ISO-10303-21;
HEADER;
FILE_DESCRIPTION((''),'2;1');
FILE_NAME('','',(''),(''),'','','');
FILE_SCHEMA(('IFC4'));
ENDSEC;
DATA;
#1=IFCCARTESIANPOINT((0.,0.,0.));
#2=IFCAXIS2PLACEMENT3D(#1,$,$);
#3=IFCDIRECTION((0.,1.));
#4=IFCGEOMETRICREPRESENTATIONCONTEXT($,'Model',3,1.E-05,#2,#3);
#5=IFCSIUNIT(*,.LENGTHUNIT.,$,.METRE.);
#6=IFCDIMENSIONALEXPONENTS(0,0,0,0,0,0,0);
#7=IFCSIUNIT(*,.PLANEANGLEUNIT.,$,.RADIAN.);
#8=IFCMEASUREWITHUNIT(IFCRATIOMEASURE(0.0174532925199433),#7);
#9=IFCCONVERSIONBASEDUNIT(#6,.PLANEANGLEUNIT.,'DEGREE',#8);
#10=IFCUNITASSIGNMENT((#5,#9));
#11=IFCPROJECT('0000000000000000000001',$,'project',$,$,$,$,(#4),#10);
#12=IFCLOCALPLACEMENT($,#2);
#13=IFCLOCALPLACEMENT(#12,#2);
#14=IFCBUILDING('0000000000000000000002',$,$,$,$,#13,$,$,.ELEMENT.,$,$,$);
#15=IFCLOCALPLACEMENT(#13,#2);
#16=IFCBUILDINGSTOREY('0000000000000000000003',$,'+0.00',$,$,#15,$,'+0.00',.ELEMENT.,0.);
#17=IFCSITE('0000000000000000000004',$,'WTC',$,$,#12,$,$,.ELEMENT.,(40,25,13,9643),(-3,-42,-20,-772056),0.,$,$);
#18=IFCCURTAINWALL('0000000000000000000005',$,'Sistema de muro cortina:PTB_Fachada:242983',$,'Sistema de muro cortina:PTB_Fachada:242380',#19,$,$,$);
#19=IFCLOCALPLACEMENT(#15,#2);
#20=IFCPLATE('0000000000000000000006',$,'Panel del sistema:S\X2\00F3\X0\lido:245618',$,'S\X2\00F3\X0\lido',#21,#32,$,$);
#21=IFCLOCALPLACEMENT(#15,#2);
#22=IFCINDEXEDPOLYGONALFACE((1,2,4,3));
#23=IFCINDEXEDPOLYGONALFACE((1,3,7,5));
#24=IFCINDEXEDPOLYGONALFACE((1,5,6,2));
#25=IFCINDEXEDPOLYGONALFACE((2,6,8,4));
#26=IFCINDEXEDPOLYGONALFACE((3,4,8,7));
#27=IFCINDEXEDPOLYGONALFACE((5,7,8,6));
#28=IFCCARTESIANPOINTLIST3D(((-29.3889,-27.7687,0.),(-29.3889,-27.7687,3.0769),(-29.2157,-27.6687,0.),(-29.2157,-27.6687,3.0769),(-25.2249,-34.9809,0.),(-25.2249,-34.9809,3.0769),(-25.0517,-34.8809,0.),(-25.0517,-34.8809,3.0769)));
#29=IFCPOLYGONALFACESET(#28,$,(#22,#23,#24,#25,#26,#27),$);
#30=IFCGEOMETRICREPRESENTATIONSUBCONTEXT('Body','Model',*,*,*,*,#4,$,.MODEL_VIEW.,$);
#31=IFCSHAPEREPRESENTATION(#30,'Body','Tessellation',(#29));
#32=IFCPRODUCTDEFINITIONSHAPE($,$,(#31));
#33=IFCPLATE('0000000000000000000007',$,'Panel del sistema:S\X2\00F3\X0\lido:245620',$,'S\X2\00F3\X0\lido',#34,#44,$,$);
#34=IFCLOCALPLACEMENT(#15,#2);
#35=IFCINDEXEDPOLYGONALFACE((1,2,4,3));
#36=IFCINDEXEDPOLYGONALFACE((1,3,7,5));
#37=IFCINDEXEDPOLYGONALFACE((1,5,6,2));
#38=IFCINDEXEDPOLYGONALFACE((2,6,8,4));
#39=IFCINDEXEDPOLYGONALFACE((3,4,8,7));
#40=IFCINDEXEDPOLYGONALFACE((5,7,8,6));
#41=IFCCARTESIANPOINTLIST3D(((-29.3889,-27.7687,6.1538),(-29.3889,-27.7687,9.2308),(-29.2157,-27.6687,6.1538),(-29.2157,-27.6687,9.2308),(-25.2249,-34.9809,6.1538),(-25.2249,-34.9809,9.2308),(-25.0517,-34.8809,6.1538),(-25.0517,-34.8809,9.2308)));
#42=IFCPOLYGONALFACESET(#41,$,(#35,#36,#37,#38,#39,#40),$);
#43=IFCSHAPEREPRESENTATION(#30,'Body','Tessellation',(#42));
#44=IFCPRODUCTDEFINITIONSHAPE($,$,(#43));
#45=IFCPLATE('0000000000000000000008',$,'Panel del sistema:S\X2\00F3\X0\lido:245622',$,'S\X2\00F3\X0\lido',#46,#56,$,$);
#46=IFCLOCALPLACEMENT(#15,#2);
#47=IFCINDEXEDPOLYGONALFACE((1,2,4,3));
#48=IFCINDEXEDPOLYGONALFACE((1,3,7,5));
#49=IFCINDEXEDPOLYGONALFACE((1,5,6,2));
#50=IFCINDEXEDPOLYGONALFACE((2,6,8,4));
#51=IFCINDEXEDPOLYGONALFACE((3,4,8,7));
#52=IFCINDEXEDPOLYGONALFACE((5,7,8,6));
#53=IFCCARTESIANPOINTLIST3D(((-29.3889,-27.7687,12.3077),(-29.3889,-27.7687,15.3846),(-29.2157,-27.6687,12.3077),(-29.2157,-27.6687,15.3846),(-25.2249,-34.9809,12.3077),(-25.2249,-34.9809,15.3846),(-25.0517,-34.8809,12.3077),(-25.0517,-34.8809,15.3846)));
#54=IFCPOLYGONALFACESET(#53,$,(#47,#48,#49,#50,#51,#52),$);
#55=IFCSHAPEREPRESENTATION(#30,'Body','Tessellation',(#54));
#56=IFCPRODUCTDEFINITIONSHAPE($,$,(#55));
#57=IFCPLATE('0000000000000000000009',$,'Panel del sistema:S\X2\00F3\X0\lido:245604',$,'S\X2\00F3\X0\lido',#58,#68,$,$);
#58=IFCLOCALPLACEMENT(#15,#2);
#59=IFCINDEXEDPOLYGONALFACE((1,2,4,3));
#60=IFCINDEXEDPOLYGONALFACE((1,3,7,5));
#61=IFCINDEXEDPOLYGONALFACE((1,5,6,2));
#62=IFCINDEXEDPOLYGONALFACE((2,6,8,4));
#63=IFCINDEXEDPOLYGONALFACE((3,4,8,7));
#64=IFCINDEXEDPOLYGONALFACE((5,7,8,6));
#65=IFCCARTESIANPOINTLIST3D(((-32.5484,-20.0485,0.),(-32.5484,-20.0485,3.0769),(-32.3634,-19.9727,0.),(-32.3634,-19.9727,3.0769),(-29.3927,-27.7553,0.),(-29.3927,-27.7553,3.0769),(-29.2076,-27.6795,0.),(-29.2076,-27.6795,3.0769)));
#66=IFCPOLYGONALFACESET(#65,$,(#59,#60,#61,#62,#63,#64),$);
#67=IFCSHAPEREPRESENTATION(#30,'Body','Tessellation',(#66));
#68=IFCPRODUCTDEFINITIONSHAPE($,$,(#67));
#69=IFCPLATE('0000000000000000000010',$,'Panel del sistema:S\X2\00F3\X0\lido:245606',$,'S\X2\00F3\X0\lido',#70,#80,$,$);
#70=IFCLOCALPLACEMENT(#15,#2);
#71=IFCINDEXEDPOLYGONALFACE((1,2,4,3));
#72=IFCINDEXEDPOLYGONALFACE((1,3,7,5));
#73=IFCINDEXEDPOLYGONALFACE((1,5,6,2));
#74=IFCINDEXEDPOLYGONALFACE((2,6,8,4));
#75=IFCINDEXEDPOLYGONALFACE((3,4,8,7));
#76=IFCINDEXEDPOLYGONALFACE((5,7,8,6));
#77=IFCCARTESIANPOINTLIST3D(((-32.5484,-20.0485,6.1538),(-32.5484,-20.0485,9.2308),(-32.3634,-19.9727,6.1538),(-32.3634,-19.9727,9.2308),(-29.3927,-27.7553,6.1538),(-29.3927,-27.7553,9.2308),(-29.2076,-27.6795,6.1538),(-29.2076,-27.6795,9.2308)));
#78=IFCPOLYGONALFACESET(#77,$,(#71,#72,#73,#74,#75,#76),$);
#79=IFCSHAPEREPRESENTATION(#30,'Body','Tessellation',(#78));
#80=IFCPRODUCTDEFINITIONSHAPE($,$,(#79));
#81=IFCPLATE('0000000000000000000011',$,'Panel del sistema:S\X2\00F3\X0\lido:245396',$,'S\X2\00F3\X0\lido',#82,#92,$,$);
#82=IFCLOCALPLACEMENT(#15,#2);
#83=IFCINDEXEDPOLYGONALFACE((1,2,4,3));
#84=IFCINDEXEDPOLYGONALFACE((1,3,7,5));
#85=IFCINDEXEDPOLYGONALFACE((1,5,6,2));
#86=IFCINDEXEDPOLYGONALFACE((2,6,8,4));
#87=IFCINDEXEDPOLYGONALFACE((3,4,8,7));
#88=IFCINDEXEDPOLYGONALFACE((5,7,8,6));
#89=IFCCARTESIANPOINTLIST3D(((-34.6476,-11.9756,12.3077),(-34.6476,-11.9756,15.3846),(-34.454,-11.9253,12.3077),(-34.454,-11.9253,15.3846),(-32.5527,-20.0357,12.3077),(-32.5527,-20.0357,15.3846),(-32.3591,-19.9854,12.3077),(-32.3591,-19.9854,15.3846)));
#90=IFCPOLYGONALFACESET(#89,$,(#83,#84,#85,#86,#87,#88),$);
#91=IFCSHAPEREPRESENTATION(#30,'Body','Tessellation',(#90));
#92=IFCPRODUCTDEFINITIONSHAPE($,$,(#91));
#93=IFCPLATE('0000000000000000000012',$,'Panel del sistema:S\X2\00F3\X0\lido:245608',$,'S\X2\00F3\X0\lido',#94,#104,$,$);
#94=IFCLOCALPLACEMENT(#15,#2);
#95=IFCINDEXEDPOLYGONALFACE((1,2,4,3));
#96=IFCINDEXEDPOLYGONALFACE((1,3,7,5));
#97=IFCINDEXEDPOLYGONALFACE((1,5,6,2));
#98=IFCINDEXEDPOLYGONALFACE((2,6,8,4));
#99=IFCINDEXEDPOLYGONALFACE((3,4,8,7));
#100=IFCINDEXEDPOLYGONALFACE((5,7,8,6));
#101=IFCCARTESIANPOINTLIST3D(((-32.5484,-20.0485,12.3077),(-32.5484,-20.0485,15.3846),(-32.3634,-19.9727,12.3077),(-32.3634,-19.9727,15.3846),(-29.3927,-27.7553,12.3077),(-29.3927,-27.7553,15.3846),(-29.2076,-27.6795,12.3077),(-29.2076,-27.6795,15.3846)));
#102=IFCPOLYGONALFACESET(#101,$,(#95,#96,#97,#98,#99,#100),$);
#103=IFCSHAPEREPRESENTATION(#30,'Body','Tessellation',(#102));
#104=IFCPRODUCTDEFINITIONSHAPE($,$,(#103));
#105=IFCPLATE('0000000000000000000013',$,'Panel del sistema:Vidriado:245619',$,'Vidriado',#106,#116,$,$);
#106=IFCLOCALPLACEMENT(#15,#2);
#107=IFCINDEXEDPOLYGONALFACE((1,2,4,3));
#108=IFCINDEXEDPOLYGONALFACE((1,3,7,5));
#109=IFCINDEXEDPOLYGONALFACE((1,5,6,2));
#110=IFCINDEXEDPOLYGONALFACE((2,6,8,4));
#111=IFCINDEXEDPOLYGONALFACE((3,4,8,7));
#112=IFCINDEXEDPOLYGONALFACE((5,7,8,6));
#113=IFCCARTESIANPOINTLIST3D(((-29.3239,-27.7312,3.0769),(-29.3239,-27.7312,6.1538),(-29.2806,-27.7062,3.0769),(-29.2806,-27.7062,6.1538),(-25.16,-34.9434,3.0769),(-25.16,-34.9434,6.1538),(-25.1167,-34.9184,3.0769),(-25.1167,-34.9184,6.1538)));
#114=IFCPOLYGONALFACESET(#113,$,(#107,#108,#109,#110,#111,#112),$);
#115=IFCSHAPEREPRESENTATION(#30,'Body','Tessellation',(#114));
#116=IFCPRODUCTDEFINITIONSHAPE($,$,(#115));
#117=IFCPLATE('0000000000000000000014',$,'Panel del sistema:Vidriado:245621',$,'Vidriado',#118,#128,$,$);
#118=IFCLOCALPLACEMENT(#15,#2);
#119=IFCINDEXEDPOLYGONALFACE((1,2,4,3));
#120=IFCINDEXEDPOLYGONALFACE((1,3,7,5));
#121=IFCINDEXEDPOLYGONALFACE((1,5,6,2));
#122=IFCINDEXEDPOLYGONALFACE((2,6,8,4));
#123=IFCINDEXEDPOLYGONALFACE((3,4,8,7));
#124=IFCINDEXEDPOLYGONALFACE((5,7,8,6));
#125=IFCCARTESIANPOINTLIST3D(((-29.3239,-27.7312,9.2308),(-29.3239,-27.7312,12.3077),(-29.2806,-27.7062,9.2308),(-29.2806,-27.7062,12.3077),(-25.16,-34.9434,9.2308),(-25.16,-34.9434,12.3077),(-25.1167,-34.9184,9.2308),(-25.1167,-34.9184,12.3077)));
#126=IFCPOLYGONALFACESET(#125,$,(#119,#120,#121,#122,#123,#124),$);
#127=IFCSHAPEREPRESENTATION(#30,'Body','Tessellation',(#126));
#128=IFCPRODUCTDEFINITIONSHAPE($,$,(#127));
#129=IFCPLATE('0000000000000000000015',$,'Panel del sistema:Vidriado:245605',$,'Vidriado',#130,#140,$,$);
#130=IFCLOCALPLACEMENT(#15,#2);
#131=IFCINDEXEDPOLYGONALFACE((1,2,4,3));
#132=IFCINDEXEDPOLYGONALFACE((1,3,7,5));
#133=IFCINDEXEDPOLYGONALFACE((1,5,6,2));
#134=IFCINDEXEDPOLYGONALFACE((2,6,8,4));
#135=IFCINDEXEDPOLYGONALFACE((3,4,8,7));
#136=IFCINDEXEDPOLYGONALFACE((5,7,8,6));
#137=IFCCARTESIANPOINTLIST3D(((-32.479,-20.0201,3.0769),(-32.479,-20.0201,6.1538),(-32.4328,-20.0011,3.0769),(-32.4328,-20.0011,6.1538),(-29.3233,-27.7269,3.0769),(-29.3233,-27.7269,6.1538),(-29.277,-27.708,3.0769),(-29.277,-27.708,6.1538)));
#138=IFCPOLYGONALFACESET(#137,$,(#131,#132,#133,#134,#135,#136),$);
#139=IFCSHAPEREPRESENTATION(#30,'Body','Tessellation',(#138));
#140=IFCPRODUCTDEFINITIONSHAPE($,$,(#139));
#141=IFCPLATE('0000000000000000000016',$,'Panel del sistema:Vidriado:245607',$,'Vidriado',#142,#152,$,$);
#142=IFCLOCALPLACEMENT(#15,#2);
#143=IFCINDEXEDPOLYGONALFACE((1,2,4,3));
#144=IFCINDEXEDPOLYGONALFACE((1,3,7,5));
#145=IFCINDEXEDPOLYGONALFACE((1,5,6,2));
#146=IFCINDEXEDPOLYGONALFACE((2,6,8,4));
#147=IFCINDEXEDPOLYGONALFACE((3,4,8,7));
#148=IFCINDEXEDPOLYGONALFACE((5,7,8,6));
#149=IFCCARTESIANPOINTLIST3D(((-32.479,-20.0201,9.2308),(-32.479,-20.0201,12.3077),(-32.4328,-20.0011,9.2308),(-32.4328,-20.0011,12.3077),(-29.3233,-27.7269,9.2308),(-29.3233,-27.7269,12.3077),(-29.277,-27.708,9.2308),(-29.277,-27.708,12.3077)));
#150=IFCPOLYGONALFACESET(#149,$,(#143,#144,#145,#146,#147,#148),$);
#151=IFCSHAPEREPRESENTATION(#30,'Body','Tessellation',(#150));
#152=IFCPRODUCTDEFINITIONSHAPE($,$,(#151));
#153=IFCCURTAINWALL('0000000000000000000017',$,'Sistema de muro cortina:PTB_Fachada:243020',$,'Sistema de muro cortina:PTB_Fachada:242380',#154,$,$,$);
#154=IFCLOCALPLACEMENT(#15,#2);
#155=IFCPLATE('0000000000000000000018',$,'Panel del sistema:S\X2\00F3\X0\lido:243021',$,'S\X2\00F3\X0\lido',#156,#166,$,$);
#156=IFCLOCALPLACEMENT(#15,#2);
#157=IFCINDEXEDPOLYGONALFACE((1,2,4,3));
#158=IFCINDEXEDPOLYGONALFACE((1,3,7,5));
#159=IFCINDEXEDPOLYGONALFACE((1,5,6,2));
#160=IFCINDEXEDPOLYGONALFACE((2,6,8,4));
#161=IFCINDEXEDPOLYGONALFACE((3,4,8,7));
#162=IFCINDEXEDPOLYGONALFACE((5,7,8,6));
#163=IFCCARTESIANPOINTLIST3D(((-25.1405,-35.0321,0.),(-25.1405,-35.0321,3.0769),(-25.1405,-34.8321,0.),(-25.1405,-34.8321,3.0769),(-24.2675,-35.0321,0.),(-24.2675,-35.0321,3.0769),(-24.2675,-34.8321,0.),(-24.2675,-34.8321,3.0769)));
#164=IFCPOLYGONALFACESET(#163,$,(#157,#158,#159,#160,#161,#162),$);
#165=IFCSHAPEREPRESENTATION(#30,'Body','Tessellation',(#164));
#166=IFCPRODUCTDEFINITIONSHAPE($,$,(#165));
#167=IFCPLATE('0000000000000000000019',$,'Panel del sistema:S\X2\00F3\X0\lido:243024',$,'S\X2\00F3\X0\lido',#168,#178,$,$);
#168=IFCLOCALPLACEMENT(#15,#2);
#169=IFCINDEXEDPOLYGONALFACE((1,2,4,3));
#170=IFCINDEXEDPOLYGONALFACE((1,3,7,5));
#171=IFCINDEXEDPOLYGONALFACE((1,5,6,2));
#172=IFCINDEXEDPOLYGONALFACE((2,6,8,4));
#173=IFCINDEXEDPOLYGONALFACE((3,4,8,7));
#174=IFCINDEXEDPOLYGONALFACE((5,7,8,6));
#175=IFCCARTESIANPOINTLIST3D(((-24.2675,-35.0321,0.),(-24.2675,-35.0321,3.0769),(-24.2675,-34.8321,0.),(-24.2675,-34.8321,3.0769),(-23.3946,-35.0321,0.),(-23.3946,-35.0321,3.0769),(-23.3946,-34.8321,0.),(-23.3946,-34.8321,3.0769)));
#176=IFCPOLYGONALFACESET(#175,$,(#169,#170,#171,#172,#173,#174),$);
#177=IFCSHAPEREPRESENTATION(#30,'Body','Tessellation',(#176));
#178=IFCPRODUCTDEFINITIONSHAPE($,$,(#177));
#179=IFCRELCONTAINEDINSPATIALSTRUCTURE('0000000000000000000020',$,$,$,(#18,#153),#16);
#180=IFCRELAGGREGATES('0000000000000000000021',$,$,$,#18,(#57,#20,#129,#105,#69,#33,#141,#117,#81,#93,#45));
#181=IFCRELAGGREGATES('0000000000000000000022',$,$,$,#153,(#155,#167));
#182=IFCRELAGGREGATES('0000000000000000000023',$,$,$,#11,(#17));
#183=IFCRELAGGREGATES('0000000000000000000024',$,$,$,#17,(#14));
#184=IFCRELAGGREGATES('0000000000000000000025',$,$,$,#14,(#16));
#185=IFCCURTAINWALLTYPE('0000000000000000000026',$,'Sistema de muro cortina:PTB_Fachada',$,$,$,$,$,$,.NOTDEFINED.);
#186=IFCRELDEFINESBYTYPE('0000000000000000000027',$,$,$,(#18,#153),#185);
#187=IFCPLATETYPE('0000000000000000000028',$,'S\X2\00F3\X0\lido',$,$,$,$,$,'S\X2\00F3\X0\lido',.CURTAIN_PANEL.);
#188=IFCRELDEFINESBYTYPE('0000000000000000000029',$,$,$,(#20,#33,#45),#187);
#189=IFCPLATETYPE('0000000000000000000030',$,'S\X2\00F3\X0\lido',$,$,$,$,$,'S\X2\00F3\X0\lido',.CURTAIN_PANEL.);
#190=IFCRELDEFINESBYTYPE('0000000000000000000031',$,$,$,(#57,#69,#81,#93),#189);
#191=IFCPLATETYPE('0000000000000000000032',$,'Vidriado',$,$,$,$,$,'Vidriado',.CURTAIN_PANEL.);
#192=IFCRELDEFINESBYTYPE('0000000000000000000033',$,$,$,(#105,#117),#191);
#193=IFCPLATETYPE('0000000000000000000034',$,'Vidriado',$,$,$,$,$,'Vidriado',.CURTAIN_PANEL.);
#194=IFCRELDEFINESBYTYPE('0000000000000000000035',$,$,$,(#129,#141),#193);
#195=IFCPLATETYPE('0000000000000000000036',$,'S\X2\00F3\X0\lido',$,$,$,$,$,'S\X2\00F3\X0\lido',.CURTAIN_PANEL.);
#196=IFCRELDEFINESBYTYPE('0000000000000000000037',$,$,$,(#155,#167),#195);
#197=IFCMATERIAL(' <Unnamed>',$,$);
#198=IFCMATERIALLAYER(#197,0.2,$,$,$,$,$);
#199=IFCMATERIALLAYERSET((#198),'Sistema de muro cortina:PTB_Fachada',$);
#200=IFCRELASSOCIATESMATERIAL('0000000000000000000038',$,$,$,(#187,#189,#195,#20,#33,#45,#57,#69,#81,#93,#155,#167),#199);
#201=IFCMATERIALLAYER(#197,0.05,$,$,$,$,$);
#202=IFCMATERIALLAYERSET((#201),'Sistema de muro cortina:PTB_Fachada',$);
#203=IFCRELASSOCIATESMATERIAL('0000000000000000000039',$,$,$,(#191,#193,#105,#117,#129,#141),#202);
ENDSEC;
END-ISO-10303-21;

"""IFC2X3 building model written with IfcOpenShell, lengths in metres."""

from ifc_helpers import new_model, entity, si_unit, converted_unit, direction, frame, frame_2d, origin, origin_2d_with_axis, place, context, subcontext, project, spatial, rectangle, extrude, source, transform, mapped, material, layer, layer_set, layer_usage, type_object, type_shapes, element, aggregate, save


model = new_model("IFC2X3")

# Units and contexts
model_context = context("Model", 3, precision=1e-05, world=origin(), true_north=direction((0.0, 1.0)))
body_context = subcontext(model_context, "Body", "Model", "MODEL_VIEW")
ifc_project = project(units=[si_unit("LENGTHUNIT", "METRE"), converted_unit("PLANEANGLEUNIT", "DEGREE", entity("IfcRatioMeasure", 0.0174532925199433), si_unit("PLANEANGLEUNIT", "RADIAN"), dimensions=[0, 0, 0, 0, 0, 0, 0])], contexts=[model_context])

# Site, building, storey
site_placement = place(None, origin())
site = spatial("IfcSite", under=ifc_project, at=site_placement, Name="WTC", CompositionType="ELEMENT", RefLatitude=(40, 25, 13, 9643), RefLongitude=(-3, -42, -20, -772056), RefElevation=0.0)
building_placement = place(site_placement, origin())
building = spatial("IfcBuilding", under=site, at=building_placement, CompositionType="ELEMENT")
storey_placement = place(building_placement, origin())
storey = spatial("IfcBuildingStorey", under=building, at=storey_placement, Name="+0.00", LongName="+0.00", CompositionType="ELEMENT", Elevation=0.0)

# Curtain walls, plates
curtain_wall_type = type_object("IfcCurtainWallType", Name="Sistema de muro cortina:PTB_Fachada", PredefinedType="NOTDEFINED")
curtain_wall_1_placement = place(storey_placement, origin())
curtain_wall_1 = element("IfcCurtainWall", 1, at=curtain_wall_1_placement, inside=storey, type_object=curtain_wall_type, Name="Sistema de muro cortina:PTB_Fachada:242983", ObjectType="Sistema de muro cortina:PTB_Fachada:242380")
ifc_material_1 = material(Name=" <Unnamed>")
ifc_layer_1 = layer(ifc_material_1, 0.2)
ifc_layer_set_1 = layer_set([ifc_layer_1], Name="Sistema de muro cortina:PTB_Fachada")
ifc_layer_usage_1 = layer_usage(ifc_layer_set_1, "AXIS3", "POSITIVE", 0.0)
plate_type_1 = type_object("IfcPlateType", Name="Sólido", ElementType="Sólido", PredefinedType="CURTAIN_PANEL", material=ifc_layer_set_1)
shared_shape_1 = source(origin(), body_context, "Body", "SweptSolid", [
    extrude(rectangle(XDim=0.2, YDim=8.3279, at=origin_2d_with_axis()), frame((0.0, 0.0, 0.0), z_axis=(0.0, 0.0, 1.0), x_axis=(0.0, 1.0, 0.0)), (0.0, 0.0, 1.0), 3.0769),
])
type_shapes(plate_type_1, [shared_shape_1])
plate_1_placement = place(curtain_wall_1_placement, frame((-27.2203, -31.3248, 3.0769), z_axis=(0.0, 0.0, -1.0), x_axis=(0.5, -0.866025, 0.0)))
plate_1 = element("IfcPlate", 2, at=plate_1_placement, type_object=plate_type_1, material=ifc_layer_usage_1, Name="Panel del sistema:Sólido:245618", ObjectType="Sólido", context=body_context, shape_type="MappedRepresentation", body=[
    mapped(shared_shape_1, transform((0.0, 0.0, 0.0), scale=1.0)),
])
ifc_layer_usage_2 = layer_usage(ifc_layer_set_1, "AXIS3", "POSITIVE", 0.0)
plate_2_placement = place(curtain_wall_1_placement, frame((-27.2203, -31.3248, 9.2308), z_axis=(0.0, 0.0, -1.0), x_axis=(0.5, -0.866025, 0.0)))
plate_2 = element("IfcPlate", 3, at=plate_2_placement, type_object=plate_type_1, material=ifc_layer_usage_2, Name="Panel del sistema:Sólido:245620", ObjectType="Sólido", context=body_context, shape_type="MappedRepresentation", body=[
    mapped(shared_shape_1, transform((0.0, 0.0, 0.0), scale=1.0)),
])
ifc_layer_usage_3 = layer_usage(ifc_layer_set_1, "AXIS3", "POSITIVE", 0.0)
plate_3_placement = place(curtain_wall_1_placement, frame((-27.2203, -31.3248, 15.3846), z_axis=(0.0, 0.0, -1.0), x_axis=(0.5, -0.866025, 0.0)))
plate_3 = element("IfcPlate", 4, at=plate_3_placement, type_object=plate_type_1, material=ifc_layer_usage_3, Name="Panel del sistema:Sólido:245622", ObjectType="Sólido", context=body_context, shape_type="MappedRepresentation", body=[
    mapped(shared_shape_1, transform((0.0, 0.0, 0.0), scale=1.0)),
])
ifc_layer_usage_4 = layer_usage(ifc_layer_set_1, "AXIS3", "POSITIVE", 0.0)
plate_type_2 = type_object("IfcPlateType", Name="Sólido", ElementType="Sólido", PredefinedType="CURTAIN_PANEL", material=ifc_layer_set_1)
shared_shape_2 = source(origin(), body_context, "Body", "SweptSolid", [
    extrude(rectangle(XDim=0.2, YDim=8.3279, at=origin_2d_with_axis()), frame((0.0, 0.0, 0.0), z_axis=(0.0, 0.0, 1.0), x_axis=(0.0, 1.0, 0.0)), (0.0, 0.0, 1.0), 3.0769),
])
type_shapes(plate_type_2, [shared_shape_2])
plate_4_placement = place(curtain_wall_1_placement, frame((-30.878, -23.864, 3.0769), z_axis=(0.0, 0.0, -1.0), x_axis=(0.378935, -0.925423, 0.0)))
plate_4 = element("IfcPlate", 5, at=plate_4_placement, type_object=plate_type_2, material=ifc_layer_usage_4, Name="Panel del sistema:Sólido:245604", ObjectType="Sólido", context=body_context, shape_type="MappedRepresentation", body=[
    mapped(shared_shape_2, transform((0.0, 0.0, 0.0), scale=1.0)),
])
ifc_layer_usage_5 = layer_usage(ifc_layer_set_1, "AXIS3", "POSITIVE", 0.0)
plate_5_placement = place(curtain_wall_1_placement, frame((-30.878, -23.864, 9.2308), z_axis=(0.0, 0.0, -1.0), x_axis=(0.378935, -0.925423, 0.0)))
plate_5 = element("IfcPlate", 6, at=plate_5_placement, type_object=plate_type_2, material=ifc_layer_usage_5, Name="Panel del sistema:Sólido:245606", ObjectType="Sólido", context=body_context, shape_type="MappedRepresentation", body=[
    mapped(shared_shape_2, transform((0.0, 0.0, 0.0), scale=1.0)),
])
ifc_layer_usage_6 = layer_usage(ifc_layer_set_1, "AXIS3", "POSITIVE", 0.0)
plate_6_placement = place(curtain_wall_1_placement, frame((-33.5034, -15.9805, 15.3846), z_axis=(0.0, 0.0, -1.0), x_axis=(0.251552, -0.967844, 0.0)))
plate_6 = element("IfcPlate", 7, at=plate_6_placement, type_object=plate_type_2, material=ifc_layer_usage_6, Name="Panel del sistema:Sólido:245396", ObjectType="Sólido", context=body_context, shape_type="MappedRepresentation", body=[
    mapped(shared_shape_2, transform((0.0, 0.0, 0.0), scale=1.0)),
])
ifc_layer_usage_7 = layer_usage(ifc_layer_set_1, "AXIS3", "POSITIVE", 0.0)
plate_7_placement = place(curtain_wall_1_placement, frame((-30.878, -23.864, 15.3846), z_axis=(0.0, 0.0, -1.0), x_axis=(0.378935, -0.925423, 0.0)))
plate_7 = element("IfcPlate", 8, at=plate_7_placement, type_object=plate_type_2, material=ifc_layer_usage_7, Name="Panel del sistema:Sólido:245608", ObjectType="Sólido", context=body_context, shape_type="MappedRepresentation", body=[
    mapped(shared_shape_2, transform((0.0, 0.0, 0.0), scale=1.0)),
])
ifc_layer_2 = layer(ifc_material_1, 0.05)
ifc_layer_set_2 = layer_set([ifc_layer_2], Name="Sistema de muro cortina:PTB_Fachada")
ifc_layer_usage_8 = layer_usage(ifc_layer_set_2, "AXIS3", "POSITIVE", 0.0)
plate_type_3 = type_object("IfcPlateType", Name="Vidriado", ElementType="Vidriado", PredefinedType="CURTAIN_PANEL", material=ifc_layer_set_2)
shared_shape_3 = source(origin(), body_context, "Body", "SweptSolid", [
    extrude(rectangle(XDim=0.05, YDim=8.3279, at=origin_2d_with_axis()), frame((0.0, 0.0, 0.0), z_axis=(0.0, 0.0, 1.0), x_axis=(0.0, 1.0, 0.0)), (0.0, 0.0, 1.0), 3.0769),
])
type_shapes(plate_type_3, [shared_shape_3])
plate_8_placement = place(curtain_wall_1_placement, frame((-27.2203, -31.3248, 6.1538), z_axis=(0.0, 0.0, -1.0), x_axis=(0.5, -0.866025, 0.0)))
plate_8 = element("IfcPlate", 9, at=plate_8_placement, type_object=plate_type_3, material=ifc_layer_usage_8, Name="Panel del sistema:Vidriado:245619", ObjectType="Vidriado", context=body_context, shape_type="MappedRepresentation", body=[
    mapped(shared_shape_3, transform((0.0, 0.0, 0.0), scale=1.0)),
])
ifc_layer_usage_9 = layer_usage(ifc_layer_set_2, "AXIS3", "POSITIVE", 0.0)
plate_9_placement = place(curtain_wall_1_placement, frame((-27.2203, -31.3248, 12.3077), z_axis=(0.0, 0.0, -1.0), x_axis=(0.5, -0.866025, 0.0)))
plate_9 = element("IfcPlate", 10, at=plate_9_placement, type_object=plate_type_3, material=ifc_layer_usage_9, Name="Panel del sistema:Vidriado:245621", ObjectType="Vidriado", context=body_context, shape_type="MappedRepresentation", body=[
    mapped(shared_shape_3, transform((0.0, 0.0, 0.0), scale=1.0)),
])
ifc_layer_usage_10 = layer_usage(ifc_layer_set_2, "AXIS3", "POSITIVE", 0.0)
plate_type_4 = type_object("IfcPlateType", Name="Vidriado", ElementType="Vidriado", PredefinedType="CURTAIN_PANEL", material=ifc_layer_set_2)
shared_shape_4 = source(origin(), body_context, "Body", "SweptSolid", [
    extrude(rectangle(XDim=0.05, YDim=8.3279, at=frame_2d((0.0, 0.0), x_axis=(1.0, 0.0))), frame((0.0, 0.0, 0.0), z_axis=(0.0, 0.0, 1.0), x_axis=(0.0, 1.0, 0.0)), (0.0, 0.0, 1.0), 3.0769),
])
type_shapes(plate_type_4, [shared_shape_4])
plate_10_placement = place(curtain_wall_1_placement, frame((-30.878, -23.864, 6.1538), z_axis=(0.0, 0.0, -1.0), x_axis=(0.378935, -0.925423, 0.0)))
plate_10 = element("IfcPlate", 11, at=plate_10_placement, type_object=plate_type_4, material=ifc_layer_usage_10, Name="Panel del sistema:Vidriado:245605", ObjectType="Vidriado", context=body_context, shape_type="MappedRepresentation", body=[
    mapped(shared_shape_4, transform((0.0, 0.0, 0.0), scale=1.0)),
])
ifc_layer_usage_11 = layer_usage(ifc_layer_set_2, "AXIS3", "POSITIVE", 0.0)
plate_11_placement = place(curtain_wall_1_placement, frame((-30.878, -23.864, 12.3077), z_axis=(0.0, 0.0, -1.0), x_axis=(0.378935, -0.925423, 0.0)))
plate_11 = element("IfcPlate", 12, at=plate_11_placement, type_object=plate_type_4, material=ifc_layer_usage_11, Name="Panel del sistema:Vidriado:245607", ObjectType="Vidriado", context=body_context, shape_type="MappedRepresentation", body=[
    mapped(shared_shape_4, transform((0.0, 0.0, 0.0), scale=1.0)),
])
aggregate(curtain_wall_1, [plate_4, plate_1, plate_10, plate_8, plate_5, plate_2, plate_11, plate_9, plate_6, plate_7, plate_3])
curtain_wall_2_placement = place(storey_placement, origin())
curtain_wall_2 = element("IfcCurtainWall", 13, at=curtain_wall_2_placement, inside=storey, type_object=curtain_wall_type, Name="Sistema de muro cortina:PTB_Fachada:243020", ObjectType="Sistema de muro cortina:PTB_Fachada:242380")
ifc_layer_usage_12 = layer_usage(ifc_layer_set_1, "AXIS3", "POSITIVE", 0.0)
plate_type_5 = type_object("IfcPlateType", Name="Sólido", ElementType="Sólido", PredefinedType="CURTAIN_PANEL", material=ifc_layer_set_1)
shared_shape_5 = source(origin(), body_context, "Body", "SweptSolid", [
    extrude(rectangle(XDim=0.2, YDim=0.873, at=origin_2d_with_axis()), frame((0.0, 0.0, 0.0), z_axis=(0.0, 0.0, 1.0), x_axis=(0.0, 1.0, 0.0)), (0.0, 0.0, 1.0), 3.0769),
])
type_shapes(plate_type_5, [shared_shape_5])
plate_12_placement = place(curtain_wall_2_placement, frame((-24.704, -34.9321, 0.0)))
plate_12 = element("IfcPlate", 14, at=plate_12_placement, type_object=plate_type_5, material=ifc_layer_usage_12, Name="Panel del sistema:Sólido:243021", ObjectType="Sólido", context=body_context, shape_type="MappedRepresentation", body=[
    mapped(shared_shape_5, transform((0.0, 0.0, 0.0), scale=1.0)),
])
ifc_layer_usage_13 = layer_usage(ifc_layer_set_1, "AXIS3", "POSITIVE", 0.0)
plate_13_placement = place(curtain_wall_2_placement, frame((-23.831, -34.9321, 0.0)))
plate_13 = element("IfcPlate", 15, at=plate_13_placement, type_object=plate_type_5, material=ifc_layer_usage_13, Name="Panel del sistema:Sólido:243024", ObjectType="Sólido", context=body_context, shape_type="MappedRepresentation", body=[
    mapped(shared_shape_5, transform((0.0, 0.0, 0.0), scale=1.0)),
])
aggregate(curtain_wall_2, [plate_12, plate_13])

save(model, "model.ifc")
